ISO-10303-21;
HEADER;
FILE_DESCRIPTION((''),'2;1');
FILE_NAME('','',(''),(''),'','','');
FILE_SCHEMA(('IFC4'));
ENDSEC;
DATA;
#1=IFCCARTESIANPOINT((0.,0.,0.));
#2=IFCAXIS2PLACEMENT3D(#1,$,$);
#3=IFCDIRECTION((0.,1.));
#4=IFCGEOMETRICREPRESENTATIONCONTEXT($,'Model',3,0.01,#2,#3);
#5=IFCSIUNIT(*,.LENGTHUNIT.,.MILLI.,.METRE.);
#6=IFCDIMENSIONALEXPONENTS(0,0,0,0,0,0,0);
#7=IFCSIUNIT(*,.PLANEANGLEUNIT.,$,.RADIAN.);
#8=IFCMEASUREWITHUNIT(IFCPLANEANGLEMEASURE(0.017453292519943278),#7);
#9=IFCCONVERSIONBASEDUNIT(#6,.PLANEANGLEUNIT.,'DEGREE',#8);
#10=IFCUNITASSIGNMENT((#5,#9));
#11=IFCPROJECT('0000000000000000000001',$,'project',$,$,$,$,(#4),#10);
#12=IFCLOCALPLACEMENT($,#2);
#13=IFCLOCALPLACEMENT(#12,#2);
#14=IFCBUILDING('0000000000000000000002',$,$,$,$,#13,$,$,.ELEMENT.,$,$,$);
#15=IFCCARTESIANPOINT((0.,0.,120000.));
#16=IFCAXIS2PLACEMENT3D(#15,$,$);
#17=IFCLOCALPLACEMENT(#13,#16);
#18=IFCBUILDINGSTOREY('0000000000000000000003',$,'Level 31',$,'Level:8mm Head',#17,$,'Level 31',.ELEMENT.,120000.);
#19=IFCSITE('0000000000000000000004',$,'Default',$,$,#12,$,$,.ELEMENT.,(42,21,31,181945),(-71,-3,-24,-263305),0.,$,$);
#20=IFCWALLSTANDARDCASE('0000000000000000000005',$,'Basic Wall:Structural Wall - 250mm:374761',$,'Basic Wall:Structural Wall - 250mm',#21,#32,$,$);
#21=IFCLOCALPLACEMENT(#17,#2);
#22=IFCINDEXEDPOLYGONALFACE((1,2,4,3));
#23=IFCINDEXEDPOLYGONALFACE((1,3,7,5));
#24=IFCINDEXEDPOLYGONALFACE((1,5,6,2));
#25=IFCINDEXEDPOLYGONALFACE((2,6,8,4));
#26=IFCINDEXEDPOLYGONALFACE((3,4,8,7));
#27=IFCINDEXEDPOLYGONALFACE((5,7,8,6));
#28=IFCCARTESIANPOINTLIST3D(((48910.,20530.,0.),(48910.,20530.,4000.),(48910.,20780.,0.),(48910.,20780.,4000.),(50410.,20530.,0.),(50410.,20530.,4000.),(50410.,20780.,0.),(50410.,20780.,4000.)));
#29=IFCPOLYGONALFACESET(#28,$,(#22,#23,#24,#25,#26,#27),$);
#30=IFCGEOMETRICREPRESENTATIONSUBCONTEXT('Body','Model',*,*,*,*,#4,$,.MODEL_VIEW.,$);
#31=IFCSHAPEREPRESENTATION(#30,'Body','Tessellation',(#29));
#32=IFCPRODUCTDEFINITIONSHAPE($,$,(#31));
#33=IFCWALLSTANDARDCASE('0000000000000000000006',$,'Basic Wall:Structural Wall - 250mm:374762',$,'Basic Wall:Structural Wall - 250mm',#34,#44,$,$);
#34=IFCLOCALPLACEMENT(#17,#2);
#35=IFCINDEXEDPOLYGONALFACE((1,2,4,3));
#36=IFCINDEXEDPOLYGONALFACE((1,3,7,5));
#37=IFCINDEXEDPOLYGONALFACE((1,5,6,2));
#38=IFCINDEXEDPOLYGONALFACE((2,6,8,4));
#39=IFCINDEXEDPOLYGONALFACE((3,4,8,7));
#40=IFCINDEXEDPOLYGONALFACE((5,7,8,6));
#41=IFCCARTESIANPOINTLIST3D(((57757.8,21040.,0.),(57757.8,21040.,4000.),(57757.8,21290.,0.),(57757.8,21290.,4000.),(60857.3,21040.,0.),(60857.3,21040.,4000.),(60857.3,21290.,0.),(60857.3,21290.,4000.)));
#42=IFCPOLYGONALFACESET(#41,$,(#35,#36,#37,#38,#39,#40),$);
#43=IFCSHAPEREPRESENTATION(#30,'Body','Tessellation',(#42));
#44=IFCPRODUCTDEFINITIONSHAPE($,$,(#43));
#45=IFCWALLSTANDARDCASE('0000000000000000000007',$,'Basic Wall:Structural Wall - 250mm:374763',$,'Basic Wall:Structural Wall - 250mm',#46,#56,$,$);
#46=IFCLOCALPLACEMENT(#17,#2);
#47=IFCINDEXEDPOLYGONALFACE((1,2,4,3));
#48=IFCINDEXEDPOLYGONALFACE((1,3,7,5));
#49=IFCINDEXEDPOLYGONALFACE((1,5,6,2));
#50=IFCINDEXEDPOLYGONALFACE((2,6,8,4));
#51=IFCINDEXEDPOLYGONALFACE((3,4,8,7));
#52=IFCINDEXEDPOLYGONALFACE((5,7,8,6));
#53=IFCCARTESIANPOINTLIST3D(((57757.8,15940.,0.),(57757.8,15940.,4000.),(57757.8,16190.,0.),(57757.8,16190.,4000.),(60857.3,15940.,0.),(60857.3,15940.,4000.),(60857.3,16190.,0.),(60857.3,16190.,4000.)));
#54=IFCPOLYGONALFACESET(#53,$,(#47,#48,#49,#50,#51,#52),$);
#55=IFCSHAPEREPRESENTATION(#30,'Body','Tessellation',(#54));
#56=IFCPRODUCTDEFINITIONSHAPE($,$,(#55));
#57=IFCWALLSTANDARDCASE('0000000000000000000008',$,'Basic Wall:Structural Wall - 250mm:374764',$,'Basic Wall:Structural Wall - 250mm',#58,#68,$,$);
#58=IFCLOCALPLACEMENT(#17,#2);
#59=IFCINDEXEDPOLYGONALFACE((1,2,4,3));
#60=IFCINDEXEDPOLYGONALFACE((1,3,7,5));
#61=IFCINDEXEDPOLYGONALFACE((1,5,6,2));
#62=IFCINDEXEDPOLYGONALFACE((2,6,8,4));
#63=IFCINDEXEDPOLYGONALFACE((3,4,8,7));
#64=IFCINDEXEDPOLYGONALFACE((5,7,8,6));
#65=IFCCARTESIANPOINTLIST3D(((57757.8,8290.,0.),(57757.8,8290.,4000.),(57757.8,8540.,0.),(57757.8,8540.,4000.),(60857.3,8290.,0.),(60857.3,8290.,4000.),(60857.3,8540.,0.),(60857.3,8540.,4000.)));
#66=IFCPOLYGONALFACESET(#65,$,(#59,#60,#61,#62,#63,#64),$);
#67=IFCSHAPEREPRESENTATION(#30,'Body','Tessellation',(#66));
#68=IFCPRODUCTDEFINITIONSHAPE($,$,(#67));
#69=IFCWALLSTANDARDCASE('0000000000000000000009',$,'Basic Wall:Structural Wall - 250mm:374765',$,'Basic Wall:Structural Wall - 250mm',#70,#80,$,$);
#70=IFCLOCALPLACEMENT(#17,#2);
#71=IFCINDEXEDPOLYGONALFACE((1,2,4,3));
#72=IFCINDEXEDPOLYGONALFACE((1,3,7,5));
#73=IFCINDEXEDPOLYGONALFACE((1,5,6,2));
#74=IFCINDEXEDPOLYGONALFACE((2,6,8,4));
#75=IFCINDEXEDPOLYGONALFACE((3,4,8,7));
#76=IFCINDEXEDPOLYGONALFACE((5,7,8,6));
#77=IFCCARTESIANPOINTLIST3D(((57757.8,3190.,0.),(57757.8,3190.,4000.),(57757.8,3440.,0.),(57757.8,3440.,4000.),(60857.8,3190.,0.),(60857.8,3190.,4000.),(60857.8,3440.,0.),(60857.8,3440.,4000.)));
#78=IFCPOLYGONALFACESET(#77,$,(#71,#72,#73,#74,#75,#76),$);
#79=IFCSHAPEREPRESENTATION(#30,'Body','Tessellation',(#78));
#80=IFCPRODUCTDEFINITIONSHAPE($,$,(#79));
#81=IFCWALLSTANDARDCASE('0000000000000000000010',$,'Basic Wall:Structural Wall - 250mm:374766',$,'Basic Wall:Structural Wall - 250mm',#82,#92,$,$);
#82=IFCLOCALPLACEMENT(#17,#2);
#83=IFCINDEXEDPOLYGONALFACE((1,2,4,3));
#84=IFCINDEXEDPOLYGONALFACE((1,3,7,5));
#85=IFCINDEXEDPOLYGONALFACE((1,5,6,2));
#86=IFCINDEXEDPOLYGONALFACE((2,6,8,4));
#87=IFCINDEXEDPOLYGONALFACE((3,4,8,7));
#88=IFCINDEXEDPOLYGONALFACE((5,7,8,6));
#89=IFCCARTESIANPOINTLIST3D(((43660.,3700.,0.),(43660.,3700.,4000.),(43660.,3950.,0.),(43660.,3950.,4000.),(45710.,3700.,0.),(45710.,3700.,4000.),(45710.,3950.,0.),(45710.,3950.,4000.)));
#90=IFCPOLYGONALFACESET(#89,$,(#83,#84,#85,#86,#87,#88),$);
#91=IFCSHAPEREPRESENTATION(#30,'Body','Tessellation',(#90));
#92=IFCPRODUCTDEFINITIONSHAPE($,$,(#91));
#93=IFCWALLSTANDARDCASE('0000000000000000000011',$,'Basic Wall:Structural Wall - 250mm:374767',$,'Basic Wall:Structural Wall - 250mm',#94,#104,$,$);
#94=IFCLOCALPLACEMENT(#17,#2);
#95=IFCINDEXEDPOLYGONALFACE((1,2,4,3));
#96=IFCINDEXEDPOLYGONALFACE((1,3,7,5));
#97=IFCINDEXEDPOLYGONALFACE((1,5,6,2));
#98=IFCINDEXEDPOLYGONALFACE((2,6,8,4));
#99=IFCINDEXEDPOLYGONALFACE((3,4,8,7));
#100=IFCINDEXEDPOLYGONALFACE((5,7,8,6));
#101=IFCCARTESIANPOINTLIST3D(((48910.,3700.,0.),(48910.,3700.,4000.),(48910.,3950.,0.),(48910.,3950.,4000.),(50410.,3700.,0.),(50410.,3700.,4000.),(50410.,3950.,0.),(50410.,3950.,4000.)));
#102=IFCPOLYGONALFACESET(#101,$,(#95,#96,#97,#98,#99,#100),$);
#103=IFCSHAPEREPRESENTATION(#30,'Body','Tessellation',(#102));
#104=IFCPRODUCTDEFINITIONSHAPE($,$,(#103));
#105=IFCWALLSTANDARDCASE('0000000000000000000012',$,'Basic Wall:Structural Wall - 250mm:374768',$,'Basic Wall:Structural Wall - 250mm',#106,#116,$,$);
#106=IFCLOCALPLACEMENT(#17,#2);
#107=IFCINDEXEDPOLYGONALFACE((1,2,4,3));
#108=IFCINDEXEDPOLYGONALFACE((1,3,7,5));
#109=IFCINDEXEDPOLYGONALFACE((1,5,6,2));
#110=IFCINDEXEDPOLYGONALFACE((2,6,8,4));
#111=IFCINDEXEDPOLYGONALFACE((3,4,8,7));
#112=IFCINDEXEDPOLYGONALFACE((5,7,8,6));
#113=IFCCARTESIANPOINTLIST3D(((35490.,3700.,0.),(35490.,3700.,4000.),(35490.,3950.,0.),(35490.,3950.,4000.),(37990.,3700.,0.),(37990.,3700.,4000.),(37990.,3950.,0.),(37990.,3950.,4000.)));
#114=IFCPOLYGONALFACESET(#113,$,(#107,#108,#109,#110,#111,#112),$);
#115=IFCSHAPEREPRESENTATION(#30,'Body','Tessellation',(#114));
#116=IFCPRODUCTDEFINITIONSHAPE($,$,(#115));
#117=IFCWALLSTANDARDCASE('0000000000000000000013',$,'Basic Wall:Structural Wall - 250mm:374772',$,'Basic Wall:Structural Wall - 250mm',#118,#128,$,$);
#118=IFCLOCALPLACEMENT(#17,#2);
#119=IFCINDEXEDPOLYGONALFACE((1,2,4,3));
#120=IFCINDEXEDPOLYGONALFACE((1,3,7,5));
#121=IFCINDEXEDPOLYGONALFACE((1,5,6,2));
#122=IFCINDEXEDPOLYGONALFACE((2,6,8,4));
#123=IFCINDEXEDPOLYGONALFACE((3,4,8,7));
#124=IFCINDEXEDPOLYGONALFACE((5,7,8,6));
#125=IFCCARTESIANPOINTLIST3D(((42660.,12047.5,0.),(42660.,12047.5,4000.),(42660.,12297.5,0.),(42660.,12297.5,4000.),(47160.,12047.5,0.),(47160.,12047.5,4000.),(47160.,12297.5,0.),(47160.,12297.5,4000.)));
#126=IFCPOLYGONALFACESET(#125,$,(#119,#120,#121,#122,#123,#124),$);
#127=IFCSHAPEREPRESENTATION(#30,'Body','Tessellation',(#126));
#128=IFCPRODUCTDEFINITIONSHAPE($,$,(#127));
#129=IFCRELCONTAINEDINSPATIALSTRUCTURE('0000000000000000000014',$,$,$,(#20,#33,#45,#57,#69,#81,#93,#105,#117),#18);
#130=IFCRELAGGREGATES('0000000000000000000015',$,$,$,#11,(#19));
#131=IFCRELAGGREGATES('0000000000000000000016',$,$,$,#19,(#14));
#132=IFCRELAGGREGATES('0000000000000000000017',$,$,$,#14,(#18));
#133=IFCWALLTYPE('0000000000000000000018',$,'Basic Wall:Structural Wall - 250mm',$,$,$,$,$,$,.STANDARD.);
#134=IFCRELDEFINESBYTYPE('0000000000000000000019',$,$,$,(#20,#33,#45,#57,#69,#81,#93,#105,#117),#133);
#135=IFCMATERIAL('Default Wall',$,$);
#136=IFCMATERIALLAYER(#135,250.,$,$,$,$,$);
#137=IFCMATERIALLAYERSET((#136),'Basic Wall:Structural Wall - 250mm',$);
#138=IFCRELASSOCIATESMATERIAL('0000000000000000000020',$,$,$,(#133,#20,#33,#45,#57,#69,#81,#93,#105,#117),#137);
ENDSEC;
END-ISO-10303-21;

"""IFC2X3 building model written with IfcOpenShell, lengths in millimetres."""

from ifc_helpers import new_model, entity, si_unit, converted_unit, direction, frame, frame_2d, origin, place, context, subcontext, project, spatial, rectangle, extrude, material, layer, layer_set, layer_usage, type_object, element, save


model = new_model("IFC2X3")

# Units and contexts
model_context = context("Model", 3, precision=0.01, world=origin(), true_north=direction((0.0, 1.0)))
body_context = subcontext(model_context, "Body", "Model", "MODEL_VIEW")
ifc_project = project(units=[si_unit("LENGTHUNIT", "METRE", prefix="MILLI"), converted_unit("PLANEANGLEUNIT", "DEGREE", entity("IfcPlaneAngleMeasure", 0.017453292519943278), si_unit("PLANEANGLEUNIT", "RADIAN"), dimensions=[0, 0, 0, 0, 0, 0, 0])], contexts=[model_context])

# Site, building, storey
site_placement = place(None, origin())
site = spatial("IfcSite", under=ifc_project, at=site_placement, Name="Default", CompositionType="ELEMENT", RefLatitude=(42, 21, 31, 181945), RefLongitude=(-71, -3, -24, -263305), RefElevation=0.0)
building_placement = place(site_placement, origin())
building = spatial("IfcBuilding", under=site, at=building_placement, CompositionType="ELEMENT")
storey_placement = place(building_placement, frame((0.0, 0.0, 120000.0)))
storey = spatial("IfcBuildingStorey", under=building, at=storey_placement, Name="Level 31", ObjectType="Level:8mm Head", LongName="Level 31", CompositionType="ELEMENT", Elevation=120000.0)

# Walls
ifc_material_1 = material(Name="Default Wall")
ifc_layer_1 = layer(ifc_material_1, 250.0)
ifc_layer_set_1 = layer_set([ifc_layer_1], Name="Basic Wall:Structural Wall - 250mm")
wall_type_1 = type_object("IfcWallType", Name="Basic Wall:Structural Wall - 250mm", PredefinedType="STANDARD", material=ifc_layer_set_1)
ifc_layer_usage_1 = layer_usage(ifc_layer_set_1, "AXIS2", "NEGATIVE", 125.0)
wall_1_placement = place(storey_placement, frame((48910.0, 20655.0, 0.0)))
element("IfcWallStandardCase", 1, at=wall_1_placement, inside=storey, type_object=wall_type_1, material=ifc_layer_usage_1, Name="Basic Wall:Structural Wall - 250mm:374761", ObjectType="Basic Wall:Structural Wall - 250mm", context=body_context, shape_type="SweptSolid", body=[
    extrude(rectangle(XDim=1500.0, YDim=250.0, at=frame_2d((750.0, 0.0), x_axis=(-1.0, 0.0))), origin(), (0.0, 0.0, 1.0), 4000.0),
])
ifc_layer_usage_2 = layer_usage(ifc_layer_set_1, "AXIS2", "NEGATIVE", 125.0)
wall_2_placement = place(storey_placement, frame((57757.8, 21165.0, 0.0)))
element("IfcWallStandardCase", 2, at=wall_2_placement, inside=storey, type_object=wall_type_1, material=ifc_layer_usage_2, Name="Basic Wall:Structural Wall - 250mm:374762", ObjectType="Basic Wall:Structural Wall - 250mm", context=body_context, shape_type="SweptSolid", body=[
    extrude(rectangle(XDim=3099.5, YDim=250.0, at=frame_2d((1549.8, 0.0), x_axis=(-1.0, 0.0))), origin(), (0.0, 0.0, 1.0), 4000.0),
])
ifc_layer_usage_3 = layer_usage(ifc_layer_set_1, "AXIS2", "NEGATIVE", 125.0)
wall_3_placement = place(storey_placement, frame((57757.8, 16065.0, 0.0)))
element("IfcWallStandardCase", 3, at=wall_3_placement, inside=storey, type_object=wall_type_1, material=ifc_layer_usage_3, Name="Basic Wall:Structural Wall - 250mm:374763", ObjectType="Basic Wall:Structural Wall - 250mm", context=body_context, shape_type="SweptSolid", body=[
    extrude(rectangle(XDim=3099.5, YDim=250.0, at=frame_2d((1549.8, 0.0), x_axis=(-1.0, 0.0))), origin(), (0.0, 0.0, 1.0), 4000.0),
])
ifc_layer_usage_4 = layer_usage(ifc_layer_set_1, "AXIS2", "POSITIVE", -125.0)
wall_4_placement = place(storey_placement, frame((57757.8, 8415.0, 0.0)))
element("IfcWallStandardCase", 4, at=wall_4_placement, inside=storey, type_object=wall_type_1, material=ifc_layer_usage_4, Name="Basic Wall:Structural Wall - 250mm:374764", ObjectType="Basic Wall:Structural Wall - 250mm", context=body_context, shape_type="SweptSolid", body=[
    extrude(rectangle(XDim=3099.5, YDim=250.0, at=frame_2d((1549.8, 0.0), x_axis=(-1.0, 0.0))), origin(), (0.0, 0.0, 1.0), 4000.0),
])
ifc_layer_usage_5 = layer_usage(ifc_layer_set_1, "AXIS2", "POSITIVE", -125.0)
wall_5_placement = place(storey_placement, frame((57757.8, 3315.0, 0.0)))
element("IfcWallStandardCase", 5, at=wall_5_placement, inside=storey, type_object=wall_type_1, material=ifc_layer_usage_5, Name="Basic Wall:Structural Wall - 250mm:374765", ObjectType="Basic Wall:Structural Wall - 250mm", context=body_context, shape_type="SweptSolid", body=[
    extrude(rectangle(XDim=3100.0, YDim=250.0, at=frame_2d((1550.0, 0.0), x_axis=(-1.0, 0.0))), origin(), (0.0, 0.0, 1.0), 4000.0),
])
ifc_layer_usage_6 = layer_usage(ifc_layer_set_1, "AXIS2", "POSITIVE", -125.0)
wall_6_placement = place(storey_placement, frame((43660.0, 3825.0, 0.0)))
element("IfcWallStandardCase", 6, at=wall_6_placement, inside=storey, type_object=wall_type_1, material=ifc_layer_usage_6, Name="Basic Wall:Structural Wall - 250mm:374766", ObjectType="Basic Wall:Structural Wall - 250mm", context=body_context, shape_type="SweptSolid", body=[
    extrude(rectangle(XDim=2050.0, YDim=250.0, at=frame_2d((1025.0, 0.0), x_axis=(-1.0, 0.0))), origin(), (0.0, 0.0, 1.0), 4000.0),
])
ifc_layer_usage_7 = layer_usage(ifc_layer_set_1, "AXIS2", "POSITIVE", -125.0)
wall_7_placement = place(storey_placement, frame((48910.0, 3825.0, 0.0)))
element("IfcWallStandardCase", 7, at=wall_7_placement, inside=storey, type_object=wall_type_1, material=ifc_layer_usage_7, Name="Basic Wall:Structural Wall - 250mm:374767", ObjectType="Basic Wall:Structural Wall - 250mm", context=body_context, shape_type="SweptSolid", body=[
    extrude(rectangle(XDim=1500.0, YDim=250.0, at=frame_2d((750.0, 0.0), x_axis=(-1.0, 0.0))), origin(), (0.0, 0.0, 1.0), 4000.0),
])
ifc_layer_usage_8 = layer_usage(ifc_layer_set_1, "AXIS2", "POSITIVE", -125.0)
wall_8_placement = place(storey_placement, frame((35490.0, 3825.0, 0.0)))
element("IfcWallStandardCase", 8, at=wall_8_placement, inside=storey, type_object=wall_type_1, material=ifc_layer_usage_8, Name="Basic Wall:Structural Wall - 250mm:374768", ObjectType="Basic Wall:Structural Wall - 250mm", context=body_context, shape_type="SweptSolid", body=[
    extrude(rectangle(XDim=2500.0, YDim=250.0, at=frame_2d((1250.0, 0.0), x_axis=(-1.0, 0.0))), origin(), (0.0, 0.0, 1.0), 4000.0),
])
ifc_layer_usage_9 = layer_usage(ifc_layer_set_1, "AXIS2", "NEGATIVE", 125.0)
wall_9_placement = place(storey_placement, frame((42660.0, 12172.5, 0.0)))
element("IfcWallStandardCase", 9, at=wall_9_placement, inside=storey, type_object=wall_type_1, material=ifc_layer_usage_9, Name="Basic Wall:Structural Wall - 250mm:374772", ObjectType="Basic Wall:Structural Wall - 250mm", context=body_context, shape_type="SweptSolid", body=[
    extrude(rectangle(XDim=4500.0, YDim=250.0, at=frame_2d((2250.0, 0.0), x_axis=(-1.0, 0.0))), origin(), (0.0, 0.0, 1.0), 4000.0),
])

save(model, "model.ifc")
